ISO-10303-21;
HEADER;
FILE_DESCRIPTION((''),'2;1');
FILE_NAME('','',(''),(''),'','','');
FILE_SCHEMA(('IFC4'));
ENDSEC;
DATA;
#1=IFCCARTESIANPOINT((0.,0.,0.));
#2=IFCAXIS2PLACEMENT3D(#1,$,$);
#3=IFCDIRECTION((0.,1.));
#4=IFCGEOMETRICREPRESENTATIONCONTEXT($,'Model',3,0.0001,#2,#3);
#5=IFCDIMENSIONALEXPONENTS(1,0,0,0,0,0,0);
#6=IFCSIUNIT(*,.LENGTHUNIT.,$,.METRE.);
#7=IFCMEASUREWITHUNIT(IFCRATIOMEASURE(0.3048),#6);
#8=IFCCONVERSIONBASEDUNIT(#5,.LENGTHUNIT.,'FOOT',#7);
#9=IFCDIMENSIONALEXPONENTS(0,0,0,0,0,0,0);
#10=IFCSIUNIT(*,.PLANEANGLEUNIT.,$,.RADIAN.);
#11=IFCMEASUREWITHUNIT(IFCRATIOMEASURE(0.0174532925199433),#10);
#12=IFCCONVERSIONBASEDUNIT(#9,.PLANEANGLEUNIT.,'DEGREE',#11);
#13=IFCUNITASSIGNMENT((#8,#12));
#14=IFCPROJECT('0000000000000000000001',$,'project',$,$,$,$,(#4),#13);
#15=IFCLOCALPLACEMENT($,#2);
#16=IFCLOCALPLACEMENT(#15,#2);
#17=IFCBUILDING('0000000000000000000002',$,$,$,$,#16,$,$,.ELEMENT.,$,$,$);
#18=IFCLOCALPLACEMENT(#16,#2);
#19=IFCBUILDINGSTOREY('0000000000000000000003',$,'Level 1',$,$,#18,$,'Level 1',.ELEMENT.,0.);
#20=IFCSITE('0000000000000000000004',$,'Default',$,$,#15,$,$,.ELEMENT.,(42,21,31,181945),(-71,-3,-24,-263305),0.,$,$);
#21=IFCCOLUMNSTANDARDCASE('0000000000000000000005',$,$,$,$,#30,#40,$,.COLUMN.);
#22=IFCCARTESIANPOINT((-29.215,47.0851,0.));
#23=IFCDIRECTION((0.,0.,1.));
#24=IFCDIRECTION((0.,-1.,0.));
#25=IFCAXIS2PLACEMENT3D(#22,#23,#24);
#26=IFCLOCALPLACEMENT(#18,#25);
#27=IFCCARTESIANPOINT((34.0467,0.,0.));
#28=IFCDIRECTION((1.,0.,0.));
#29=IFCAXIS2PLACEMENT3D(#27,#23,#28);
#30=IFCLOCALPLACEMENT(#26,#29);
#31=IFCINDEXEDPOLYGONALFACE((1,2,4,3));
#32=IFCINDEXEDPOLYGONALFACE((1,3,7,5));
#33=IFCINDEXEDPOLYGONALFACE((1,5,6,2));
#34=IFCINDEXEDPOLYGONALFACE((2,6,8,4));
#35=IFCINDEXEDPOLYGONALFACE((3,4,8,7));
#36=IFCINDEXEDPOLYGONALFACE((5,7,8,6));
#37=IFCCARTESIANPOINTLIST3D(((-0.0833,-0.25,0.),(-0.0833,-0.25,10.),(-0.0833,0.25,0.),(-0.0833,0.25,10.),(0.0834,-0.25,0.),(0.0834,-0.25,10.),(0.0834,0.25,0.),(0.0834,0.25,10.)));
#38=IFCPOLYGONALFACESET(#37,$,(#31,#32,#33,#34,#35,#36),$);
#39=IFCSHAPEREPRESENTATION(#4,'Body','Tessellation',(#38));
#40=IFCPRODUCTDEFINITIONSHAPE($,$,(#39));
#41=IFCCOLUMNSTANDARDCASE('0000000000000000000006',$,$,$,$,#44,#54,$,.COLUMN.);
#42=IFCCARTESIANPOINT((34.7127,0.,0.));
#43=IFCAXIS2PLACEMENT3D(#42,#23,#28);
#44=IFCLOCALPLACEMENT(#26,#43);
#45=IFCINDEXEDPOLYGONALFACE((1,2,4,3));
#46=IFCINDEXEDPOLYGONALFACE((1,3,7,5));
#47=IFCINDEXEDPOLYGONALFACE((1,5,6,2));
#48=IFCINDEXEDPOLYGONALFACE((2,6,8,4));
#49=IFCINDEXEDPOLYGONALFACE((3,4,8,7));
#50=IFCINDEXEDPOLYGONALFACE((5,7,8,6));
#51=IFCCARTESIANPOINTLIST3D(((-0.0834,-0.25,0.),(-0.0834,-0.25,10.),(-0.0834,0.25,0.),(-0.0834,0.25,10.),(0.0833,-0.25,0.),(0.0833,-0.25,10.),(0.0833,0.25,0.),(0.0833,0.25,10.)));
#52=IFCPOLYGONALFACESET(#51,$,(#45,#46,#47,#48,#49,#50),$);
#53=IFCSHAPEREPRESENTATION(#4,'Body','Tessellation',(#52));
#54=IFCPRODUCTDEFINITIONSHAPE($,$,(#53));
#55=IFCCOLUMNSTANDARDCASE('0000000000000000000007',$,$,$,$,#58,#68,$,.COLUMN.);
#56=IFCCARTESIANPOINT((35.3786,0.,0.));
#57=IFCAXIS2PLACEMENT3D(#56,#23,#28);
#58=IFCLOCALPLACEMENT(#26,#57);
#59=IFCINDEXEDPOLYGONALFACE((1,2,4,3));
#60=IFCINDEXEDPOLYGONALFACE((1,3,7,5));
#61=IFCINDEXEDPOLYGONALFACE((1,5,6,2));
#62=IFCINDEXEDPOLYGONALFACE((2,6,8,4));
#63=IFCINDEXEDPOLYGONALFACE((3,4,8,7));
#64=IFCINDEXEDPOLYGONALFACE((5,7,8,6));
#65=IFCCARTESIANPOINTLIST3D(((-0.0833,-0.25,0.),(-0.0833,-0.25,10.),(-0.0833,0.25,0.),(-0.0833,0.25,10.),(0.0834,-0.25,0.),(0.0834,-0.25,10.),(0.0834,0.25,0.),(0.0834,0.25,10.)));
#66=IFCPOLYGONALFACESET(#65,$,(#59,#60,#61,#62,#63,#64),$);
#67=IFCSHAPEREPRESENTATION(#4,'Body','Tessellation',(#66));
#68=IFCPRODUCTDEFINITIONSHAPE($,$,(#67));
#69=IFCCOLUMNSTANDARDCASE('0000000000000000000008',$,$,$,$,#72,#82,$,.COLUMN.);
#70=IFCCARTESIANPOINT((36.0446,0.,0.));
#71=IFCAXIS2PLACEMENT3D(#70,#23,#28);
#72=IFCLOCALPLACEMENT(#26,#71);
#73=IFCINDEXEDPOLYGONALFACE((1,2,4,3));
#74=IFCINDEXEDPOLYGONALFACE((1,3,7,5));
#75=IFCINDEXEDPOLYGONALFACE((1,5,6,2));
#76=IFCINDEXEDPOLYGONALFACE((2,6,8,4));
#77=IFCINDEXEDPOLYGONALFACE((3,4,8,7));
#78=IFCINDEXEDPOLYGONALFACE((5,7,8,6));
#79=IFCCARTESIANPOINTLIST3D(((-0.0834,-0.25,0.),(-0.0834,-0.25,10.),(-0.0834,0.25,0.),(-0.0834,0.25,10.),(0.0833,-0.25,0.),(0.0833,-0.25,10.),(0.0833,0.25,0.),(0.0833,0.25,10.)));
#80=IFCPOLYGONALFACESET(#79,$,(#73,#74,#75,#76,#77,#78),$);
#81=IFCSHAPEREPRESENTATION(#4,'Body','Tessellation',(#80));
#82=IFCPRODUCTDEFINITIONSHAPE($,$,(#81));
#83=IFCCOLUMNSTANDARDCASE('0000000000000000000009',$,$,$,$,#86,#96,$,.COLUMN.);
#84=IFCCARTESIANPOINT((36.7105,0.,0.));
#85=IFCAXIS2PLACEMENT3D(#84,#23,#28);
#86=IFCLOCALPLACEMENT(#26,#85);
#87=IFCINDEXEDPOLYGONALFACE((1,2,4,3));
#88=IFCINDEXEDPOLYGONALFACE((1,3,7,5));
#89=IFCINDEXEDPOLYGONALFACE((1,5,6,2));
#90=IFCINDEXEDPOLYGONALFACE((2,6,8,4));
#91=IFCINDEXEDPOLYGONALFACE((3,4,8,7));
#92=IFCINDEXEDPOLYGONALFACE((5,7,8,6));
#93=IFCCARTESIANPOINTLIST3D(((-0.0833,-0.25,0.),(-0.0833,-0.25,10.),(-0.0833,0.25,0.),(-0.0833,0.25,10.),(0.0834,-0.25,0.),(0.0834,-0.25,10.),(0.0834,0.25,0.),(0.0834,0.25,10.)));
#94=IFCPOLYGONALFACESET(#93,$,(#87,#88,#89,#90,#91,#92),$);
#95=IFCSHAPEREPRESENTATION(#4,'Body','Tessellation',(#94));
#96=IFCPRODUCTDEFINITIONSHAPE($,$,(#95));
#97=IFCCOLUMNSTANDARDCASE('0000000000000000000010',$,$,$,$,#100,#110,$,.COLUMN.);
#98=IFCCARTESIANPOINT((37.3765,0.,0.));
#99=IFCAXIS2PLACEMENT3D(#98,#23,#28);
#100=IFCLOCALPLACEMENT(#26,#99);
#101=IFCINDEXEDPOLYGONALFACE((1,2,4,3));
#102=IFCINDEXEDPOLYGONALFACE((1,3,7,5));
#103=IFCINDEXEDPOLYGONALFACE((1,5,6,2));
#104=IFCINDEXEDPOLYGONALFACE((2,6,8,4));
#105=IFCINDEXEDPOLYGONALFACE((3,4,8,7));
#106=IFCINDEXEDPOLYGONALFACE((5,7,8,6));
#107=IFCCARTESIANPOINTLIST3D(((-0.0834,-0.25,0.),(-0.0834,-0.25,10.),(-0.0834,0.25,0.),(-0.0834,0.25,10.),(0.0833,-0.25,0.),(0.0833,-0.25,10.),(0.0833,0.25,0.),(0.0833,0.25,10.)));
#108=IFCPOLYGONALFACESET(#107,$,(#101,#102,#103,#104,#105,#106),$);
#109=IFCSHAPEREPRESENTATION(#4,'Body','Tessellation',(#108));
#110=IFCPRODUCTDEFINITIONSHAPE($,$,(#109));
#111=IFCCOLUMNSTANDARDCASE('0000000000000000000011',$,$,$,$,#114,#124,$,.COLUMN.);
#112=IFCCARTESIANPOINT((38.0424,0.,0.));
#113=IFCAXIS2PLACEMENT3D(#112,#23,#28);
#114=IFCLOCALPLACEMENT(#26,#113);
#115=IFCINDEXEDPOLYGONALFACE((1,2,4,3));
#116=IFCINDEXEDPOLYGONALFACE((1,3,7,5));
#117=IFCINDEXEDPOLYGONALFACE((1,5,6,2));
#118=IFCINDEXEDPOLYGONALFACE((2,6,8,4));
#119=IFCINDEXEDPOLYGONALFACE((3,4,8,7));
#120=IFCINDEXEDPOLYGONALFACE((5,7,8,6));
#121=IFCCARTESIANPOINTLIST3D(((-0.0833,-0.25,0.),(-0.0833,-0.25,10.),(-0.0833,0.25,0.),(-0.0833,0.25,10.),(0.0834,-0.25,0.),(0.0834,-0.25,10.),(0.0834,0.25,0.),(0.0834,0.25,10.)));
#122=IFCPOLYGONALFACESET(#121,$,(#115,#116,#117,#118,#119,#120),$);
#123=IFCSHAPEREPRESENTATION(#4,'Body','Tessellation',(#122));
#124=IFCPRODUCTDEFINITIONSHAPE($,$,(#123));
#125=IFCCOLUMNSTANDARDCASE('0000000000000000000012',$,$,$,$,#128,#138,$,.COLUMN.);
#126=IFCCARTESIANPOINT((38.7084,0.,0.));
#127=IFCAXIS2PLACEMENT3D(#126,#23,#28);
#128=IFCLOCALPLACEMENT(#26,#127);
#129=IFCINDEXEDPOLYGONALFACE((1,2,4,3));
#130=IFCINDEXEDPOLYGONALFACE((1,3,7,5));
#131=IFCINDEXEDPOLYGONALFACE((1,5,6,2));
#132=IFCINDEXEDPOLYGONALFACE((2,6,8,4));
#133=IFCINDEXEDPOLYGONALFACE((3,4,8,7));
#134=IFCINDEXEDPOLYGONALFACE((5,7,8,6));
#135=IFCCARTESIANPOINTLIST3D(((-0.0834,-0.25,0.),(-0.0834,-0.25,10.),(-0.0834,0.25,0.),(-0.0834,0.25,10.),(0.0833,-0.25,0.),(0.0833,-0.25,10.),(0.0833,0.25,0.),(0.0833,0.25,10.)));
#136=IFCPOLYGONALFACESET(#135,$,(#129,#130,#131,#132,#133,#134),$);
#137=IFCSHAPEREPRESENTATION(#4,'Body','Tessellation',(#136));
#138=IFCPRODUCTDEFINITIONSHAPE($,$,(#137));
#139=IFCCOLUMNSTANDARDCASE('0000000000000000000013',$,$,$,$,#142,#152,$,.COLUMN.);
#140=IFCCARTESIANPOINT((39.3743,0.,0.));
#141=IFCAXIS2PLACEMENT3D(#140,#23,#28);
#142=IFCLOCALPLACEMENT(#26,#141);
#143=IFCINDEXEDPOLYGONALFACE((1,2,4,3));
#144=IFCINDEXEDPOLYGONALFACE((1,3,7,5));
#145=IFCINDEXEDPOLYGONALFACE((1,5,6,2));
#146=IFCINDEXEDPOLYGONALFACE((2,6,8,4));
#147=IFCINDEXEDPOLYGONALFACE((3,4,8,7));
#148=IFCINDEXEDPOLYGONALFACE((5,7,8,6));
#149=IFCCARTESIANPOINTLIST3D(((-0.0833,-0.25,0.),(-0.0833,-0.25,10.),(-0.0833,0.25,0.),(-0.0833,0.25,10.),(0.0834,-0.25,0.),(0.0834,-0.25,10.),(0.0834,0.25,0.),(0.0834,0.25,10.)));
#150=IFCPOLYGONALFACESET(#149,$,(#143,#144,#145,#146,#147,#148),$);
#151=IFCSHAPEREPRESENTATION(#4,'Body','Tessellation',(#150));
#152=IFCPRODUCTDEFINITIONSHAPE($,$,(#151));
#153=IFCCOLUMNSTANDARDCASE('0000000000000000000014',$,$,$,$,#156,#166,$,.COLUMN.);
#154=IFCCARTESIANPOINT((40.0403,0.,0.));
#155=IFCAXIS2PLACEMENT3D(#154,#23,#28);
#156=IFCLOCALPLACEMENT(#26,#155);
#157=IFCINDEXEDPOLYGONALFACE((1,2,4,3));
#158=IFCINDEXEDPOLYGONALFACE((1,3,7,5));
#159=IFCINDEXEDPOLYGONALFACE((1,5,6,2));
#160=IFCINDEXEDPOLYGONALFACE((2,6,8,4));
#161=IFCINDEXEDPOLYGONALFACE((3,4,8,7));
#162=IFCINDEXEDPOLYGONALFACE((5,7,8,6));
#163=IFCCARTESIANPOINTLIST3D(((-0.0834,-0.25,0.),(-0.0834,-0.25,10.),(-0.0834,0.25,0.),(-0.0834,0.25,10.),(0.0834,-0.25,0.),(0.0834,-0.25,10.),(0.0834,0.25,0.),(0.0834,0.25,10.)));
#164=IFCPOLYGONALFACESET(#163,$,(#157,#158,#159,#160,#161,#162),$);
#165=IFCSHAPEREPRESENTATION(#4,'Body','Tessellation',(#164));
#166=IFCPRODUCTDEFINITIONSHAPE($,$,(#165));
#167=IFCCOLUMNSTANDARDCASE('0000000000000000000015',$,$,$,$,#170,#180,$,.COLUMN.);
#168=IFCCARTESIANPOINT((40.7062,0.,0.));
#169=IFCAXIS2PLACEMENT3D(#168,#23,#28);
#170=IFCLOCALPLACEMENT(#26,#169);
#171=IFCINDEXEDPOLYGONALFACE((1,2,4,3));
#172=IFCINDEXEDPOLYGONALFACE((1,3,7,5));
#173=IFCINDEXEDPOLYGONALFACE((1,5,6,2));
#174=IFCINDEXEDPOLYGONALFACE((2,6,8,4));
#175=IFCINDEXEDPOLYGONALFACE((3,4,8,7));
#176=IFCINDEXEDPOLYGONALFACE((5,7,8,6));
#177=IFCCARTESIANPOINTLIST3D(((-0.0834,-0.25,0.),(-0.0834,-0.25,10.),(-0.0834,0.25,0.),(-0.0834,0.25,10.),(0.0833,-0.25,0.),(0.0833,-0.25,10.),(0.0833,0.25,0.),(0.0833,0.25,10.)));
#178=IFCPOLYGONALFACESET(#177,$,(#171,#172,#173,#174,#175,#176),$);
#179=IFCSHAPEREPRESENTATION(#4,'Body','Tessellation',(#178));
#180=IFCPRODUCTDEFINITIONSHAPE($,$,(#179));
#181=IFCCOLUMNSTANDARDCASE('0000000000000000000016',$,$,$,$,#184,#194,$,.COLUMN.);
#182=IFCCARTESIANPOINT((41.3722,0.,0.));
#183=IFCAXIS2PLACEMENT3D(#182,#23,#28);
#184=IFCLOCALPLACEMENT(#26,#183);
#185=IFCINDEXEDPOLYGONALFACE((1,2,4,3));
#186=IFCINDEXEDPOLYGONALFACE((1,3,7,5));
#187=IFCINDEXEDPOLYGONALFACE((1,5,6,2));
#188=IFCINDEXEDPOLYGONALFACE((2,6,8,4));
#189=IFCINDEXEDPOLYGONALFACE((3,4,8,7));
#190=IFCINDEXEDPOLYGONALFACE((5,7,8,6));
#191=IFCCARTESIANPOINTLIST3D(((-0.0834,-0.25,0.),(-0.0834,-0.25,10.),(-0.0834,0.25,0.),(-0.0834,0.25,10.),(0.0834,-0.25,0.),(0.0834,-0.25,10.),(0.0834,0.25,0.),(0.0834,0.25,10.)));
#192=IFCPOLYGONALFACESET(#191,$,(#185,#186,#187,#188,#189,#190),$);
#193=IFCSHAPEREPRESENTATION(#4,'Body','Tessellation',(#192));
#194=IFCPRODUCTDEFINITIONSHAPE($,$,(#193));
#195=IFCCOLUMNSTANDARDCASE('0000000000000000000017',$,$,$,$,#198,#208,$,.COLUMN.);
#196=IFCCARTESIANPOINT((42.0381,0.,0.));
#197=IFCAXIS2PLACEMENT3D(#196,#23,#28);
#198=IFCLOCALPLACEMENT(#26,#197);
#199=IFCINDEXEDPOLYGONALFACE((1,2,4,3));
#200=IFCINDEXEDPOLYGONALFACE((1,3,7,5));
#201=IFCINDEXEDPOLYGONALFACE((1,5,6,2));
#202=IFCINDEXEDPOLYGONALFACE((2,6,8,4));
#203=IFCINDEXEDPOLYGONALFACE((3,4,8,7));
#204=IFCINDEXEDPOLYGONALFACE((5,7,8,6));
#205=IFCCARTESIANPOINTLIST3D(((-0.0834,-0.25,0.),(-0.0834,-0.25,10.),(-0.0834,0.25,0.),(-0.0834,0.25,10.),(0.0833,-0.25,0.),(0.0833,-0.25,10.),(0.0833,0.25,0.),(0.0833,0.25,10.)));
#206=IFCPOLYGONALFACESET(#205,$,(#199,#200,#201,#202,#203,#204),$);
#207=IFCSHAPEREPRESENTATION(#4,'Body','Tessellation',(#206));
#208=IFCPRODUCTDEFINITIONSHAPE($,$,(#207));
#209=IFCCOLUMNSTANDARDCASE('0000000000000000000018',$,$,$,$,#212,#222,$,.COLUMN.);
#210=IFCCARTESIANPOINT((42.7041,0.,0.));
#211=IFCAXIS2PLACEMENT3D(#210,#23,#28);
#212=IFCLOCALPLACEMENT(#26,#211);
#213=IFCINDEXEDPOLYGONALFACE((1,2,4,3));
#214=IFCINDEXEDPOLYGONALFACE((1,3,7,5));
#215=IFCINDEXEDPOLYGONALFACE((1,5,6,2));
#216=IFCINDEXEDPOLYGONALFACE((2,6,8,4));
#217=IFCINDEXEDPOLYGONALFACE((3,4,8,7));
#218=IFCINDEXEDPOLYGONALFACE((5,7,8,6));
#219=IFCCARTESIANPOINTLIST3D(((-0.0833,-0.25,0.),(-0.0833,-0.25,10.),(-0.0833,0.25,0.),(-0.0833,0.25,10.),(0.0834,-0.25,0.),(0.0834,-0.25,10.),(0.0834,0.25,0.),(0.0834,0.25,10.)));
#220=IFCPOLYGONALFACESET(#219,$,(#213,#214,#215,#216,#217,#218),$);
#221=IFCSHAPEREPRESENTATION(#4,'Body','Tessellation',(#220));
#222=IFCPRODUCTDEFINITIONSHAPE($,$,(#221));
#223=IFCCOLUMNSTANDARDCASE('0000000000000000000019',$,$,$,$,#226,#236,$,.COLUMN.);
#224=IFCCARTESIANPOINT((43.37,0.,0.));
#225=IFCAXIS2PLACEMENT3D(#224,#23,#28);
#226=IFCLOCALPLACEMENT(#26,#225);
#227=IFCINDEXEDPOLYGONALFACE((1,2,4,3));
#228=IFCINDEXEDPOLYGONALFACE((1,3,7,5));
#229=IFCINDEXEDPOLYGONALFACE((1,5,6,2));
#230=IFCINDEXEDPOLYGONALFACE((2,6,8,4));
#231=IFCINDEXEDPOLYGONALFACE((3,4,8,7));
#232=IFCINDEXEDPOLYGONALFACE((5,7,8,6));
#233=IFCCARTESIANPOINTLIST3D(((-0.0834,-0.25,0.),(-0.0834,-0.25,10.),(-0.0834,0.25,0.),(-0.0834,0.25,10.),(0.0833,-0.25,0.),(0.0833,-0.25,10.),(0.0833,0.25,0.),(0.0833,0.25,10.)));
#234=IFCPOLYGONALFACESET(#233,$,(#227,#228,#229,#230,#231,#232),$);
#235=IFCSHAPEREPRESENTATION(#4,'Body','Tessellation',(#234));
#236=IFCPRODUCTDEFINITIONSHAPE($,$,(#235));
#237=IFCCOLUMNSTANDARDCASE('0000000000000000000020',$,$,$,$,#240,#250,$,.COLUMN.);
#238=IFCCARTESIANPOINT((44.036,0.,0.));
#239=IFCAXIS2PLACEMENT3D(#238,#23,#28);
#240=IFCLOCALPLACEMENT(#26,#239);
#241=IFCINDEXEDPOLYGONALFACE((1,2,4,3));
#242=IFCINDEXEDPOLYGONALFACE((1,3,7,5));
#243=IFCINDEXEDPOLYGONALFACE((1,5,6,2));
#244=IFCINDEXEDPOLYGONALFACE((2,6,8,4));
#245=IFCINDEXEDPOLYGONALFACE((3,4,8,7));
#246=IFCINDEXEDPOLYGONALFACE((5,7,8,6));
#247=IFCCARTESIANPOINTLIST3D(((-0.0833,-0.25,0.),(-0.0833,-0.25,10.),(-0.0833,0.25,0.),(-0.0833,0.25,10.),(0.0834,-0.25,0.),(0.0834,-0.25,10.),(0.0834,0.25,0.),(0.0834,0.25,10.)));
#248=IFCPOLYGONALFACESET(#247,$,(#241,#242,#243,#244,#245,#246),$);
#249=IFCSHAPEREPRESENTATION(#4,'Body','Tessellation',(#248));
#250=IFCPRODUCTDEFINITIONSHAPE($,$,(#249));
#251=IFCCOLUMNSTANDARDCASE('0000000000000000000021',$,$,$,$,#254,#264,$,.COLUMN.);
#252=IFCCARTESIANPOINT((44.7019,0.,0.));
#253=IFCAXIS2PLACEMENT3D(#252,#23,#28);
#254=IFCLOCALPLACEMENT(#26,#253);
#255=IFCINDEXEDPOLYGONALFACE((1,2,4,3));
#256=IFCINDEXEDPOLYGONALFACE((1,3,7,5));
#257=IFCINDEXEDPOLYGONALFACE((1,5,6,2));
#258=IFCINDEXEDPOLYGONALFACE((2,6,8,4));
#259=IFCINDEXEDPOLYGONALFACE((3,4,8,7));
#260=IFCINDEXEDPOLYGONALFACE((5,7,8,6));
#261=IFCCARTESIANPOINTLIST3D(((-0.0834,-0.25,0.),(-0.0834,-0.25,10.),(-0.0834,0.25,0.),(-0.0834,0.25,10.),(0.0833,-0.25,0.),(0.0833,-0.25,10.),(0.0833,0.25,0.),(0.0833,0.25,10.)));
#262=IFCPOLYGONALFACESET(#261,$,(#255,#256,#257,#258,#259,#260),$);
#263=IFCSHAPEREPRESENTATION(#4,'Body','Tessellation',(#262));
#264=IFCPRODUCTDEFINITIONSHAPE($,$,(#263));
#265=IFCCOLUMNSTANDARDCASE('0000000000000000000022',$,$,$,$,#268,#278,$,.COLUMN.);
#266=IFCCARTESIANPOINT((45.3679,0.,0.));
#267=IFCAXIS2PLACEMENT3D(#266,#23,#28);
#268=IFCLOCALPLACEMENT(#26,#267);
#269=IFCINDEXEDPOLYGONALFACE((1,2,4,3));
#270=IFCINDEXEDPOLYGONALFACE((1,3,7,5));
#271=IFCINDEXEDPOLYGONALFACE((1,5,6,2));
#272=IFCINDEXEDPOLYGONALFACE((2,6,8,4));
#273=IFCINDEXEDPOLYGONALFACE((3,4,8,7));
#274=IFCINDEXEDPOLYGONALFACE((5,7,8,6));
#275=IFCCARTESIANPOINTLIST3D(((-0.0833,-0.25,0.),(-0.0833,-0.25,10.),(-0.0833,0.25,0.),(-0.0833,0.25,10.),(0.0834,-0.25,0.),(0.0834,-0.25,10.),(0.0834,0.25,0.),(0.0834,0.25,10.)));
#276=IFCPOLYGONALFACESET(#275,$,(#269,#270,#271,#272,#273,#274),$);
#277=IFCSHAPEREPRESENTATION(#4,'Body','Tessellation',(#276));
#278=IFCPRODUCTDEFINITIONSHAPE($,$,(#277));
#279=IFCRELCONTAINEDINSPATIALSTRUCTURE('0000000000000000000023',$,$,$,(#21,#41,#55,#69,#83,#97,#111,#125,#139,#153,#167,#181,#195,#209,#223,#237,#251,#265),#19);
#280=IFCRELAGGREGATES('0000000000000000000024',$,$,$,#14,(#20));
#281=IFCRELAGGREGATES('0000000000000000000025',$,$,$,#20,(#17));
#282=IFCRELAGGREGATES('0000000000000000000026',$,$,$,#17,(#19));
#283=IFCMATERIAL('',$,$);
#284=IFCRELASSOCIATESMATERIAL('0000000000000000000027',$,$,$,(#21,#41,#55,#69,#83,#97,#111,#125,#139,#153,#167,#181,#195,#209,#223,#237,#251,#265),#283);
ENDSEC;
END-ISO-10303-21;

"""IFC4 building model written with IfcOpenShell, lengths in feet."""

from ifc_helpers import new_model, entity, si_unit, converted_unit, direction, frame, origin, place, context, project, spatial, rectangle, extrude, material, element, save


model = new_model("IFC4")

# Units and contexts
model_context = context("Model", 3, precision=0.0001, world=origin(), true_north=direction((0.0, 1.0)))
ifc_project = project(units=[converted_unit("LENGTHUNIT", "FOOT", entity("IfcRatioMeasure", 0.3048), si_unit("LENGTHUNIT", "METRE"), dimensions=[1, 0, 0, 0, 0, 0, 0]), converted_unit("PLANEANGLEUNIT", "DEGREE", entity("IfcRatioMeasure", 0.0174532925199433), si_unit("PLANEANGLEUNIT", "RADIAN"), dimensions=[0, 0, 0, 0, 0, 0, 0])], contexts=[model_context])

# Site, building, storey
site_placement = place(None, origin())
site = spatial("IfcSite", under=ifc_project, at=site_placement, Name="Default", CompositionType="ELEMENT", RefLatitude=(42, 21, 31, 181945), RefLongitude=(-71, -3, -24, -263305), RefElevation=0.0)
building_placement = place(site_placement, origin())
building = spatial("IfcBuilding", under=site, at=building_placement, CompositionType="ELEMENT")
storey_placement = place(building_placement, origin())
storey = spatial("IfcBuildingStorey", under=building, at=storey_placement, Name="Level 1", LongName="Level 1", CompositionType="ELEMENT", Elevation=0.0)

# Columns
ifc_material_1 = material(Name="")
placement = place(storey_placement, frame((-29.215, 47.0851, 0.0), z_axis=(0.0, 0.0, 1.0), x_axis=(0.0, -1.0, 0.0)))
for number, where, z_axis, x_axis in (
    (1, (34.0467, 0.0, 0.0), (0.0, 0.0, 1.0), (1.0, 0.0, 0.0)),
    (2, (34.7127, 0.0, 0.0), (0.0, 0.0, 1.0), (1.0, 0.0, 0.0)),
    (3, (35.3786, 0.0, 0.0), (0.0, 0.0, 1.0), (1.0, 0.0, 0.0)),
    (4, (36.0446, 0.0, 0.0), (0.0, 0.0, 1.0), (1.0, 0.0, 0.0)),
    (5, (36.7105, 0.0, 0.0), (0.0, 0.0, 1.0), (1.0, 0.0, 0.0)),
    (6, (37.3765, 0.0, 0.0), (0.0, 0.0, 1.0), (1.0, 0.0, 0.0)),
    (7, (38.0424, 0.0, 0.0), (0.0, 0.0, 1.0), (1.0, 0.0, 0.0)),
    (8, (38.7084, 0.0, 0.0), (0.0, 0.0, 1.0), (1.0, 0.0, 0.0)),
    (9, (39.3743, 0.0, 0.0), (0.0, 0.0, 1.0), (1.0, 0.0, 0.0)),
    (10, (40.0403, 0.0, 0.0), (0.0, 0.0, 1.0), (1.0, 0.0, 0.0)),
    (11, (40.7062, 0.0, 0.0), (0.0, 0.0, 1.0), (1.0, 0.0, 0.0)),
    (12, (41.3722, 0.0, 0.0), (0.0, 0.0, 1.0), (1.0, 0.0, 0.0)),
    (13, (42.0381, 0.0, 0.0), (0.0, 0.0, 1.0), (1.0, 0.0, 0.0)),
    (14, (42.7041, 0.0, 0.0), (0.0, 0.0, 1.0), (1.0, 0.0, 0.0)),
    (15, (43.37, 0.0, 0.0), (0.0, 0.0, 1.0), (1.0, 0.0, 0.0)),
    (16, (44.036, 0.0, 0.0), (0.0, 0.0, 1.0), (1.0, 0.0, 0.0)),
    (17, (44.7019, 0.0, 0.0), (0.0, 0.0, 1.0), (1.0, 0.0, 0.0)),
    (18, (45.3679, 0.0, 0.0), (0.0, 0.0, 1.0), (1.0, 0.0, 0.0)),
):
    element("IfcColumnStandardCase", number, at=place(placement, frame(where, z_axis=z_axis, x_axis=x_axis)), inside=storey, material=ifc_material_1, PredefinedType="COLUMN", context=model_context, shape_type="SweptSolid", body=[
        extrude(rectangle(XDim=0.1667, YDim=0.5), origin(), (0.0, 0.0, 1.0), 10.0),
    ])

save(model, "model.ifc")
